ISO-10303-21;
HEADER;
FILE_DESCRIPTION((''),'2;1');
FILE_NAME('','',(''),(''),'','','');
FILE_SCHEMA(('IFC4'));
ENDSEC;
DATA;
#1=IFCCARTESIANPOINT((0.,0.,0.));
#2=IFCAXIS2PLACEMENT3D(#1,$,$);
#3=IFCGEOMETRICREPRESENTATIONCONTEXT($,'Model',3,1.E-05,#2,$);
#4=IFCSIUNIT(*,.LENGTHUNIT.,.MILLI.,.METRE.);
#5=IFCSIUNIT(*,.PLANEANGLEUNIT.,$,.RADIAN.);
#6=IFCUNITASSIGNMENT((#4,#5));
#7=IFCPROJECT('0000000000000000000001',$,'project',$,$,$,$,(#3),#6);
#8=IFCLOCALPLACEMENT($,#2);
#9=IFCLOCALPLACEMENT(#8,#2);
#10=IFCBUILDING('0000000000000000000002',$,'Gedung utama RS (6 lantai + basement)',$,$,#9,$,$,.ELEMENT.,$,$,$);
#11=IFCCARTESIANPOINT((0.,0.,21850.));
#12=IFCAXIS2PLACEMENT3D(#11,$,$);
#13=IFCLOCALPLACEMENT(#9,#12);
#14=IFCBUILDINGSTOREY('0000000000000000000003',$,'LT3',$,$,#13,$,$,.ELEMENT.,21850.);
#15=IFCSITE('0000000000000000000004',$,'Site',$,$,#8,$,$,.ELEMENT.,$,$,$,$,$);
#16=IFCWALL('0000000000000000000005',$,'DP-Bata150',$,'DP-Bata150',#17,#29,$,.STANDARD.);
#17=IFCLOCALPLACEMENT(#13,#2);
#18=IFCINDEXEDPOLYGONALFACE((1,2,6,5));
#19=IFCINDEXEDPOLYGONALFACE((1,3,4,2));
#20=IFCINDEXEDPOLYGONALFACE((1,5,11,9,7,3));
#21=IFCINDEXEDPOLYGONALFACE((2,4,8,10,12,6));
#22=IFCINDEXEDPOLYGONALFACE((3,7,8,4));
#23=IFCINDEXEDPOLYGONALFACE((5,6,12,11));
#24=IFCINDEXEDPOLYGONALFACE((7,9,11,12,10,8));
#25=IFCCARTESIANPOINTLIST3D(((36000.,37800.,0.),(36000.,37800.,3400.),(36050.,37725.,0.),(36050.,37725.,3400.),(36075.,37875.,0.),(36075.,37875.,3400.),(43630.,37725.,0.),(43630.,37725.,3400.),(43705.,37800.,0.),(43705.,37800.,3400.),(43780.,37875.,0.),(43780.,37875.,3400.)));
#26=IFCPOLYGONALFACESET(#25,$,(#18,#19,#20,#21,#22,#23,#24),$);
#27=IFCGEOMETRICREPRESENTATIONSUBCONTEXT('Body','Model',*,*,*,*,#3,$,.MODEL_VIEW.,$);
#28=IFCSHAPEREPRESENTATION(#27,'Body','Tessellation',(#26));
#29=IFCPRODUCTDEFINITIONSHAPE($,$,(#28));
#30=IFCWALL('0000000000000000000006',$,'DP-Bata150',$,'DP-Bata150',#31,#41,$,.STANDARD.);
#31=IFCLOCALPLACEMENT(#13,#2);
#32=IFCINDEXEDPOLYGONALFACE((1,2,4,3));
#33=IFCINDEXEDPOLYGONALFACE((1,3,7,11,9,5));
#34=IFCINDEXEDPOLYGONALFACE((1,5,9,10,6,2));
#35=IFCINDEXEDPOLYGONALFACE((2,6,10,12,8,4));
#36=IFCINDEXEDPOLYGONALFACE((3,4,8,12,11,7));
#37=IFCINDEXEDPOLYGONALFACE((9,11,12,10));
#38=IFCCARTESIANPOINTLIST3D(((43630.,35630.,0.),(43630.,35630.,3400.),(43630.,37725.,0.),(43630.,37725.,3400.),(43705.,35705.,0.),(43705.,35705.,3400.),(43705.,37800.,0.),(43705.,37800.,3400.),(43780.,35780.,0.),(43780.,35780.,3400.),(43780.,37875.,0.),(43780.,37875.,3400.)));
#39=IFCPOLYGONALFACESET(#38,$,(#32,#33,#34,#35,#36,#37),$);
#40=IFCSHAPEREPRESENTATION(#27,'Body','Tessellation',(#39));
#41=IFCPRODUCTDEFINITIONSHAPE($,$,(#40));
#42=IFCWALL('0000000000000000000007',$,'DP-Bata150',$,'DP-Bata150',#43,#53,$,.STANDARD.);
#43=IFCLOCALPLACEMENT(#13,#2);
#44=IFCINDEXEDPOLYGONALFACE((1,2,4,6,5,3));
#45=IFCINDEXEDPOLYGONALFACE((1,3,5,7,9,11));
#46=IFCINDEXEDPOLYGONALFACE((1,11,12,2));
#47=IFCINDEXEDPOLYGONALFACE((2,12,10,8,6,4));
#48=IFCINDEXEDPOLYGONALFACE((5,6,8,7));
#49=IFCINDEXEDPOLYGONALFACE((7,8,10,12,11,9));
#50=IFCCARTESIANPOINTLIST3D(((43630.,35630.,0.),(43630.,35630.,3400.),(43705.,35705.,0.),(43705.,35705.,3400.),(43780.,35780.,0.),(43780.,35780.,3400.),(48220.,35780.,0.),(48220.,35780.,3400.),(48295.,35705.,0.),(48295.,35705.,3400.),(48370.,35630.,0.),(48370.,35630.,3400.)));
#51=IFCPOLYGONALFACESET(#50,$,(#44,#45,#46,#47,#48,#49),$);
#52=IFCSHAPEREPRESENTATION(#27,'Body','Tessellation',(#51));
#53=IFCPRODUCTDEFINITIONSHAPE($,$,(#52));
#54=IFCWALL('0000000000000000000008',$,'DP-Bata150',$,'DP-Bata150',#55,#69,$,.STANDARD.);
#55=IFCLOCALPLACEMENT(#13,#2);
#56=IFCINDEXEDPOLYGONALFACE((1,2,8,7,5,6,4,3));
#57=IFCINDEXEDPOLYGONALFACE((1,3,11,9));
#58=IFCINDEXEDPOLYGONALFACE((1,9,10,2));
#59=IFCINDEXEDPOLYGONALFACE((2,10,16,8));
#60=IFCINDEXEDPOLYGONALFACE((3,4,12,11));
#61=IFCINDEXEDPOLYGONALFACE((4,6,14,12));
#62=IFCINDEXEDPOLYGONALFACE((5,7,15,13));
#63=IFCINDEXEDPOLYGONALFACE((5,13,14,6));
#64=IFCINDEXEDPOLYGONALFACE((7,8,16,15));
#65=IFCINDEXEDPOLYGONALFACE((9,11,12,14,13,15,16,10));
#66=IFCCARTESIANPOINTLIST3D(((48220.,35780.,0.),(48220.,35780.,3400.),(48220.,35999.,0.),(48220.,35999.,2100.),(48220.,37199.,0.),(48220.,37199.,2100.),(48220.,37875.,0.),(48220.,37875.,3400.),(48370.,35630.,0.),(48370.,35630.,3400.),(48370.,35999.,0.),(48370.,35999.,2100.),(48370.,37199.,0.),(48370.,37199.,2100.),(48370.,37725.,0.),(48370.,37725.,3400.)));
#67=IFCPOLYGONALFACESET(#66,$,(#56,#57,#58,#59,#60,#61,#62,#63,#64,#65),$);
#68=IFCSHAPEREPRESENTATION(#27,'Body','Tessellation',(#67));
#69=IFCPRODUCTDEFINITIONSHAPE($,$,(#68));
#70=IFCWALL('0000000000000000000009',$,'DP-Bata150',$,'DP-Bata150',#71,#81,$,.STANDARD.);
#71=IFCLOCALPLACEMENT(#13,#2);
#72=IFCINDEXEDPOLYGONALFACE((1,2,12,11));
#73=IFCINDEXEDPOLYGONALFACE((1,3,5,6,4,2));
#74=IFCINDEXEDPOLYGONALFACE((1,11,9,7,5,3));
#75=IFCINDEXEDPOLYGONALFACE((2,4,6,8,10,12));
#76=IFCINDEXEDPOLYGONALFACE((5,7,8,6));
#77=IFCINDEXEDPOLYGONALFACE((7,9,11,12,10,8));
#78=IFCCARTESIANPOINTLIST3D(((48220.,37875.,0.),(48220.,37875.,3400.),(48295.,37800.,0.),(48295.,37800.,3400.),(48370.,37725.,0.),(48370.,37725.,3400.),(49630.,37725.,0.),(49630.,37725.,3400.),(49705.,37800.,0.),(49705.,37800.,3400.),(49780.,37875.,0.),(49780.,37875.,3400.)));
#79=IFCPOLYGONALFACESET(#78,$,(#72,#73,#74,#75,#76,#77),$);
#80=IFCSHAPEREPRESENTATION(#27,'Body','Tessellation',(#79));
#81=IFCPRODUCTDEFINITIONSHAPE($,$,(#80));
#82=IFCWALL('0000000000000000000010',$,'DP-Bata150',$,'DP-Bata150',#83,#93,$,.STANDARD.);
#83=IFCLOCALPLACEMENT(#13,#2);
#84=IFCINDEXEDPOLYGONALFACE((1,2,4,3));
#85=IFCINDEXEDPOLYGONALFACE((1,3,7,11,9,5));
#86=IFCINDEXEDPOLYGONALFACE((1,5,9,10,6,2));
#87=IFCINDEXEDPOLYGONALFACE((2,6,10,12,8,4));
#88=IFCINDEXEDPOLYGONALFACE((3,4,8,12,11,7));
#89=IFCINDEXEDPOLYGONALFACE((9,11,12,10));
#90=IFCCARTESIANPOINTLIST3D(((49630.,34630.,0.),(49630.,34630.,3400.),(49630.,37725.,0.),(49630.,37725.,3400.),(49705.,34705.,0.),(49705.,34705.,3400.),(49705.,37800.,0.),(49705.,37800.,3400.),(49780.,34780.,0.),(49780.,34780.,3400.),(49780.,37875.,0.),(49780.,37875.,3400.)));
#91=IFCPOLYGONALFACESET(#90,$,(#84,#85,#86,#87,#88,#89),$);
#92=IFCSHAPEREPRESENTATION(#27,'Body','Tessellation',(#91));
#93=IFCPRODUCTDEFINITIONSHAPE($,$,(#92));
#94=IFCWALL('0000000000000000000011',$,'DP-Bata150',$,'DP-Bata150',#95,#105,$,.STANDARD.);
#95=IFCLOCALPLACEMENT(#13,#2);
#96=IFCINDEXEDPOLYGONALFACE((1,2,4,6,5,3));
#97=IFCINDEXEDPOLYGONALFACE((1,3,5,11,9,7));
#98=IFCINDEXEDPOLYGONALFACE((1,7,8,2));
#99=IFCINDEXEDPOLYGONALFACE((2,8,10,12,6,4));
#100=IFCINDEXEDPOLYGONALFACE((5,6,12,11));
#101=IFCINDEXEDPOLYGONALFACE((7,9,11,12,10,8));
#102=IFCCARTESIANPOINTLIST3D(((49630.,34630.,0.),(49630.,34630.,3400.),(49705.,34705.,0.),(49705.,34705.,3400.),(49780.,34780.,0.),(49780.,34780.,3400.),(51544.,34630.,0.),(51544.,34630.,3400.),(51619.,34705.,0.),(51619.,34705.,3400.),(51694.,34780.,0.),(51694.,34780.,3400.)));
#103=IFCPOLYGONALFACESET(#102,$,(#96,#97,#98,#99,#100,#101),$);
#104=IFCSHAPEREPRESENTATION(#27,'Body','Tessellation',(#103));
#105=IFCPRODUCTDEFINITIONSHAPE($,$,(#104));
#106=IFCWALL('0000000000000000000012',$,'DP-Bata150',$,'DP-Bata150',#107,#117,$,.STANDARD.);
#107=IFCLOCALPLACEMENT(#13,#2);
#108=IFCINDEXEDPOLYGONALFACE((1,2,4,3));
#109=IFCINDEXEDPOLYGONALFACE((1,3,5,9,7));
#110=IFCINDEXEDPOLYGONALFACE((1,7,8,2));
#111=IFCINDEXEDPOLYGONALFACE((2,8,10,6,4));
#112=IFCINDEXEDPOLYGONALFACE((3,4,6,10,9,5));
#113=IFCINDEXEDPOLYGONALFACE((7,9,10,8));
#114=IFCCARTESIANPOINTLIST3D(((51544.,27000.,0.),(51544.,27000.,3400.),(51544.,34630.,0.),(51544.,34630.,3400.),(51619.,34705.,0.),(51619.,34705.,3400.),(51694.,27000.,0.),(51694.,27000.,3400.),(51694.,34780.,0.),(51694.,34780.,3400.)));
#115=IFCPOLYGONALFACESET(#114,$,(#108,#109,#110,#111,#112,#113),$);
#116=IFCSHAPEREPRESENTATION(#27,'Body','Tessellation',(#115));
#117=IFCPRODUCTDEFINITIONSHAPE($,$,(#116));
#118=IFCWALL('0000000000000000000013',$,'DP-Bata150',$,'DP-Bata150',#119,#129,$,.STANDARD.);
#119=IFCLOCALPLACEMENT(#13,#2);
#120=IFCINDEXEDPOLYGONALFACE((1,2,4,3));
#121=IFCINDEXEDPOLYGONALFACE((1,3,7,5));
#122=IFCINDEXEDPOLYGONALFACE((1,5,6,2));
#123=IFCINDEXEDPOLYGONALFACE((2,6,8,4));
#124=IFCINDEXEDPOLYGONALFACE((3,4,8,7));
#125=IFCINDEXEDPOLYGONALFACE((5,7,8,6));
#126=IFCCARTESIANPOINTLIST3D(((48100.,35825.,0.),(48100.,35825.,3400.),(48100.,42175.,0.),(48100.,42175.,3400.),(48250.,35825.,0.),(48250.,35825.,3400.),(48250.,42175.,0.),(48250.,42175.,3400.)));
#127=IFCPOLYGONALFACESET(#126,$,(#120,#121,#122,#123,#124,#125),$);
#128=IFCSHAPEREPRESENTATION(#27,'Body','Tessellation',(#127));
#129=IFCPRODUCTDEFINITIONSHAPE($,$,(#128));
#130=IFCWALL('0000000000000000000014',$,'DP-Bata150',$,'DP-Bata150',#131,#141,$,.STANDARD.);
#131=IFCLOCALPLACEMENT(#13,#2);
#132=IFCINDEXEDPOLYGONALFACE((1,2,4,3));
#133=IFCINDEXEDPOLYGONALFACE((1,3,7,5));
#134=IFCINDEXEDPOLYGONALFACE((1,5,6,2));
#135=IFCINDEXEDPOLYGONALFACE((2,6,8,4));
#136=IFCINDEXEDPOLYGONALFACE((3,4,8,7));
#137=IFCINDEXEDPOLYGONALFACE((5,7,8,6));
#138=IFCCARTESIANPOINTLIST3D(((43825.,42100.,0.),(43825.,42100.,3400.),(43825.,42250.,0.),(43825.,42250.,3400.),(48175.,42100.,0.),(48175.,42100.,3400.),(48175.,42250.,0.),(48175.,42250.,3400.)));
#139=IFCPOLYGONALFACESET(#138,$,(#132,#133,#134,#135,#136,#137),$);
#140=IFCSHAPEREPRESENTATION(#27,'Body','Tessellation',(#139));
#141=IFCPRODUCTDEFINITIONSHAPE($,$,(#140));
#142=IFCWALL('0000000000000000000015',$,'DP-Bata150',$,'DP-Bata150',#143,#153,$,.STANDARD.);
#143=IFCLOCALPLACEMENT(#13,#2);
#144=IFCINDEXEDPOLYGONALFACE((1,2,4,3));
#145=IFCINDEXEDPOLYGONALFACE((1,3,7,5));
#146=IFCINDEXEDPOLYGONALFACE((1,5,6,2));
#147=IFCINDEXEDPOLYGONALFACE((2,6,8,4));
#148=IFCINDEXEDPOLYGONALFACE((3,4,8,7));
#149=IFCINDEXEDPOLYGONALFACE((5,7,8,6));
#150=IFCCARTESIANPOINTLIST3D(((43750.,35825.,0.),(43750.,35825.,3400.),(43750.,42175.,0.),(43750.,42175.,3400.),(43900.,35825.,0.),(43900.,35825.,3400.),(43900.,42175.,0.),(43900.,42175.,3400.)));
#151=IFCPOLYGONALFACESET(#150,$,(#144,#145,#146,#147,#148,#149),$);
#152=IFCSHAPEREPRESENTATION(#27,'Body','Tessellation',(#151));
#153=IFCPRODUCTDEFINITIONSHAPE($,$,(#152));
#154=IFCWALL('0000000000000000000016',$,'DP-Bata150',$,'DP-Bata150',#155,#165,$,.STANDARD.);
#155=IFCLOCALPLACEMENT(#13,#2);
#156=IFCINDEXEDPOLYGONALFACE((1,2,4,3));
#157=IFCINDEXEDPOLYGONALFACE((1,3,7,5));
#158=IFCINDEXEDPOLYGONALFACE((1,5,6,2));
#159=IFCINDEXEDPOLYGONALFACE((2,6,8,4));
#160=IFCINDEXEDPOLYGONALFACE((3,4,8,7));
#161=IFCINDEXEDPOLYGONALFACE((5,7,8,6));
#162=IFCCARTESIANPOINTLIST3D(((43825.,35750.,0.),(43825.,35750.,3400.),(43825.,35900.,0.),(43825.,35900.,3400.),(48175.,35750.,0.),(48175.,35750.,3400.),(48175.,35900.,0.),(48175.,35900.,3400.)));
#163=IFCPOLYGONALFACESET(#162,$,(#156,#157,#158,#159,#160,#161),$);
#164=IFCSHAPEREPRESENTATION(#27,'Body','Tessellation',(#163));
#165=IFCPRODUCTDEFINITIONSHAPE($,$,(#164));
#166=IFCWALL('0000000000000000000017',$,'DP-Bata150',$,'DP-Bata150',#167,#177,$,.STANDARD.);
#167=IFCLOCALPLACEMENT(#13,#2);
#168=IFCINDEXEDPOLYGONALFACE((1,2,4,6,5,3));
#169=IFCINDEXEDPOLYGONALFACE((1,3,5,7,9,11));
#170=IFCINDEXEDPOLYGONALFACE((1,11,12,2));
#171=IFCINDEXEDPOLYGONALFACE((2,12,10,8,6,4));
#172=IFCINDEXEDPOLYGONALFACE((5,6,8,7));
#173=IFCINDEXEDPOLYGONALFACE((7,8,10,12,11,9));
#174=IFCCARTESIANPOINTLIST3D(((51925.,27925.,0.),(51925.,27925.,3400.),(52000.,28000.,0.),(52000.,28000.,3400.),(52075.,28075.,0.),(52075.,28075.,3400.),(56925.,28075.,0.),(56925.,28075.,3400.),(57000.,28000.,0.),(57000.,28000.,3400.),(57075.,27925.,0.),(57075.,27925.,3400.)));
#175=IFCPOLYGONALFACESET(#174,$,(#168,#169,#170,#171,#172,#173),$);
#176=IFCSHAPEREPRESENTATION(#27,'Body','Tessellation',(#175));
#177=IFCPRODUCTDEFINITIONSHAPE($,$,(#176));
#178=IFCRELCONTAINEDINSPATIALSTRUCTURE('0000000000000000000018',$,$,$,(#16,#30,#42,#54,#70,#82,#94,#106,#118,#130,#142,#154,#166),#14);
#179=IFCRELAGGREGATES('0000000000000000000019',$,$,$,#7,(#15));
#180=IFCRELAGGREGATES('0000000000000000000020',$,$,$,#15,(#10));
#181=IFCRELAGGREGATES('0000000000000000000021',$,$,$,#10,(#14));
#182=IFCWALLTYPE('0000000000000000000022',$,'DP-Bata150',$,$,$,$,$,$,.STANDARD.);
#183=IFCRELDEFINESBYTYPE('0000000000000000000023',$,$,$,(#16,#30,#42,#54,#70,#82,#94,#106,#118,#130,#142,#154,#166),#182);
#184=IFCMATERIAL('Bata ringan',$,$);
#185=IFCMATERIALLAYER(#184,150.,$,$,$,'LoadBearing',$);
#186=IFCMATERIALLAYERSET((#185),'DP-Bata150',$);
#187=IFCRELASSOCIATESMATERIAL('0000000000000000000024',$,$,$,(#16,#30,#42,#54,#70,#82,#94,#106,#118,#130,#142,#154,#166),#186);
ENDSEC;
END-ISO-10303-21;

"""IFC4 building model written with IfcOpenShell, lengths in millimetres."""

from ifc_helpers import new_model, si_unit, frame, frame_2d, origin, place, context, subcontext, project, spatial, polyline, rectangle, outline, extrude, material, layer, layer_set, layer_usage, type_object, element, save


model = new_model("IFC4")

# Units and contexts
model_context = context("Model", 3, precision=1e-05, world=origin())
body_context = subcontext(model_context, "Body", "Model", "MODEL_VIEW")
ifc_project = project(units=[si_unit("LENGTHUNIT", "METRE", prefix="MILLI"), si_unit("PLANEANGLEUNIT", "RADIAN")], contexts=[model_context])

# Site, building, storey
site_placement = place(None, origin())
site = spatial("IfcSite", under=ifc_project, at=site_placement, Name="Site", CompositionType="ELEMENT")
building_placement = place(site_placement, origin())
building = spatial("IfcBuilding", under=site, at=building_placement, Name="Gedung utama RS (6 lantai + basement)", CompositionType="ELEMENT")
storey_placement = place(building_placement, frame((0.0, 0.0, 21850.0)))
storey = spatial("IfcBuildingStorey", under=building, at=storey_placement, Name="LT3", CompositionType="ELEMENT", Elevation=21850.0)

# Walls
ifc_material_1 = material(Name="Bata ringan")
ifc_layer_1 = layer(ifc_material_1, 150.0, Category="LoadBearing")
ifc_layer_set_1 = layer_set([ifc_layer_1], Name="DP-Bata150")
ifc_layer_usage_1 = layer_usage(ifc_layer_set_1, "AXIS2", "NEGATIVE", 75.0)
wall_type_1 = type_object("IfcWallType", Name="DP-Bata150", PredefinedType="STANDARD")
wall_1_placement = place(storey_placement, frame((36000.0, 37800.0, 0.0), z_axis=(0.0, 0.0, 1.0), x_axis=(1.0, 0.0, 0.0)))
element("IfcWall", 1, at=wall_1_placement, inside=storey, type_object=wall_type_1, material=ifc_layer_usage_1, Name="DP-Bata150", ObjectType="DP-Bata150", PredefinedType="STANDARD", context=body_context, shape_type="SweptSolid", body=[
    extrude(outline(polyline([(50.0, -75.0), (0.0, 0.0), (75.0, 75.0), (7780.0, 75.0), (7705.0, 0.0), (7630.0, -75.0), (50.0, -75.0)])), origin(), (0.0, 0.0, 1.0), 3400.0),
])
wall_2_placement = place(storey_placement, frame((43705.0, 37800.0, 0.0), z_axis=(0.0, 0.0, 1.0), x_axis=(0.0, -1.0, 0.0)))
element("IfcWall", 2, at=wall_2_placement, inside=storey, type_object=wall_type_1, material=ifc_layer_usage_1, Name="DP-Bata150", ObjectType="DP-Bata150", PredefinedType="STANDARD", context=body_context, shape_type="SweptSolid", body=[
    extrude(outline(polyline([(75.0, -75.0), (0.0, 0.0), (-75.0, 75.0), (2020.0, 75.0), (2095.0, 0.0), (2170.0, -75.0), (75.0, -75.0)])), origin(), (0.0, 0.0, 1.0), 3400.0),
])
wall_3_placement = place(storey_placement, frame((43705.0, 35705.0, 0.0), z_axis=(0.0, 0.0, 1.0), x_axis=(1.0, 0.0, 0.0)))
element("IfcWall", 3, at=wall_3_placement, inside=storey, type_object=wall_type_1, material=ifc_layer_usage_1, Name="DP-Bata150", ObjectType="DP-Bata150", PredefinedType="STANDARD", context=body_context, shape_type="SweptSolid", body=[
    extrude(outline(polyline([(-75.0, -75.0), (0.0, 0.0), (75.0, 75.0), (4515.0, 75.0), (4590.0, 0.0), (4665.0, -75.0), (-75.0, -75.0)])), origin(), (0.0, 0.0, 1.0), 3400.0),
])

# Wall, opening
wall_4_placement = place(storey_placement, frame((48295.0, 35705.0, 0.0), z_axis=(0.0, 0.0, 1.0), x_axis=(0.0, 1.0, 0.0)))
wall_4 = element("IfcWall", 4, at=wall_4_placement, inside=storey, type_object=wall_type_1, material=ifc_layer_usage_1, Name="DP-Bata150", ObjectType="DP-Bata150", PredefinedType="STANDARD", context=body_context, shape_type="SweptSolid", body=[
    extrude(outline(polyline([(-75.0, -75.0), (0.0, 0.0), (75.0, 75.0), (2170.0, 75.0), (2095.0, 0.0), (2020.0, -75.0), (-75.0, -75.0)])), origin(), (0.0, 0.0, 1.0), 3400.0),
])
opening_1_placement = place(wall_4_placement, frame((294.0, 0.0, 0.0), z_axis=(0.0, 0.0, 1.0), x_axis=(1.0, 0.0, 0.0)))
element("IfcOpeningElement", 5, at=opening_1_placement, cuts=wall_4, PredefinedType="OPENING", context=body_context, shape_type="SweptSolid", body=[
    extrude(rectangle(XDim=1200.0, YDim=170.0, at=frame_2d((600.0, 0.0))), origin(), (0.0, 0.0, 1.0), 2100.0),
])

# Walls
wall_5_placement = place(storey_placement, frame((48295.0, 37800.0, 0.0), z_axis=(0.0, 0.0, 1.0), x_axis=(1.0, 0.0, 0.0)))
element("IfcWall", 6, at=wall_5_placement, inside=storey, type_object=wall_type_1, material=ifc_layer_usage_1, Name="DP-Bata150", ObjectType="DP-Bata150", PredefinedType="STANDARD", context=body_context, shape_type="SweptSolid", body=[
    extrude(outline(polyline([(75.0, -75.0), (0.0, 0.0), (-75.0, 75.0), (1485.0, 75.0), (1410.0, 0.0), (1335.0, -75.0), (75.0, -75.0)])), origin(), (0.0, 0.0, 1.0), 3400.0),
])
wall_6_placement = place(storey_placement, frame((49705.0, 37800.0, 0.0), z_axis=(0.0, 0.0, 1.0), x_axis=(0.0, -1.0, 0.0)))
element("IfcWall", 7, at=wall_6_placement, inside=storey, type_object=wall_type_1, material=ifc_layer_usage_1, Name="DP-Bata150", ObjectType="DP-Bata150", PredefinedType="STANDARD", context=body_context, shape_type="SweptSolid", body=[
    extrude(outline(polyline([(75.0, -75.0), (0.0, 0.0), (-75.0, 75.0), (3020.0, 75.0), (3095.0, 0.0), (3170.0, -75.0), (75.0, -75.0)])), origin(), (0.0, 0.0, 1.0), 3400.0),
])
wall_7_placement = place(storey_placement, frame((49705.0, 34705.0, 0.0), z_axis=(0.0, 0.0, 1.0), x_axis=(1.0, 0.0, 0.0)))
element("IfcWall", 8, at=wall_7_placement, inside=storey, type_object=wall_type_1, material=ifc_layer_usage_1, Name="DP-Bata150", ObjectType="DP-Bata150", PredefinedType="STANDARD", context=body_context, shape_type="SweptSolid", body=[
    extrude(outline(polyline([(-75.0, -75.0), (0.0, 0.0), (75.0, 75.0), (1989.0, 75.0), (1914.0, 0.0), (1839.0, -75.0), (-75.0, -75.0)])), origin(), (0.0, 0.0, 1.0), 3400.0),
])
wall_8_placement = place(storey_placement, frame((51619.0, 34705.0, 0.0), z_axis=(0.0, 0.0, 1.0), x_axis=(0.0, -1.0, 0.0)))
element("IfcWall", 9, at=wall_8_placement, inside=storey, type_object=wall_type_1, material=ifc_layer_usage_1, Name="DP-Bata150", ObjectType="DP-Bata150", PredefinedType="STANDARD", context=body_context, shape_type="SweptSolid", body=[
    extrude(outline(polyline([(75.0, -75.0), (0.0, 0.0), (-75.0, 75.0), (7705.0, 75.0), (7705.0, -75.0), (75.0, -75.0)])), origin(), (0.0, 0.0, 1.0), 3400.0),
])
wall_9_placement = place(storey_placement, frame((48175.0, 35825.0, 0.0), z_axis=(0.0, 0.0, 1.0), x_axis=(0.0, 1.0, 0.0)))
element("IfcWall", 10, at=wall_9_placement, inside=storey, type_object=wall_type_1, material=ifc_layer_usage_1, Name="DP-Bata150", ObjectType="DP-Bata150", PredefinedType="STANDARD", context=body_context, shape_type="SweptSolid", body=[
    extrude(outline(polyline([(0.0, -75.0), (0.0, 75.0), (6350.0, 75.0), (6350.0, -75.0), (0.0, -75.0)])), origin(), (0.0, 0.0, 1.0), 3400.0),
])
wall_10_placement = place(storey_placement, frame((48175.0, 42175.0, 0.0), z_axis=(0.0, 0.0, 1.0), x_axis=(-1.0, 0.0, 0.0)))
element("IfcWall", 11, at=wall_10_placement, inside=storey, type_object=wall_type_1, material=ifc_layer_usage_1, Name="DP-Bata150", ObjectType="DP-Bata150", PredefinedType="STANDARD", context=body_context, shape_type="SweptSolid", body=[
    extrude(outline(polyline([(0.0, -75.0), (0.0, 75.0), (4350.0, 75.0), (4350.0, -75.0), (0.0, -75.0)])), origin(), (0.0, 0.0, 1.0), 3400.0),
])
wall_11_placement = place(storey_placement, frame((43825.0, 42175.0, 0.0), z_axis=(0.0, 0.0, 1.0), x_axis=(0.0, -1.0, 0.0)))
element("IfcWall", 12, at=wall_11_placement, inside=storey, type_object=wall_type_1, material=ifc_layer_usage_1, Name="DP-Bata150", ObjectType="DP-Bata150", PredefinedType="STANDARD", context=body_context, shape_type="SweptSolid", body=[
    extrude(outline(polyline([(0.0, -75.0), (0.0, 75.0), (6350.0, 75.0), (6350.0, -75.0), (0.0, -75.0)])), origin(), (0.0, 0.0, 1.0), 3400.0),
])
wall_12_placement = place(storey_placement, frame((43825.0, 35825.0, 0.0), z_axis=(0.0, 0.0, 1.0), x_axis=(1.0, 0.0, 0.0)))
element("IfcWall", 13, at=wall_12_placement, inside=storey, type_object=wall_type_1, material=ifc_layer_usage_1, Name="DP-Bata150", ObjectType="DP-Bata150", PredefinedType="STANDARD", context=body_context, shape_type="SweptSolid", body=[
    extrude(outline(polyline([(0.0, -75.0), (0.0, 75.0), (4350.0, 75.0), (4350.0, -75.0), (0.0, -75.0)])), origin(), (0.0, 0.0, 1.0), 3400.0),
])
wall_13_placement = place(storey_placement, frame((52000.0, 28000.0, 0.0), z_axis=(0.0, 0.0, 1.0), x_axis=(1.0, 0.0, 0.0)))
element("IfcWall", 14, at=wall_13_placement, inside=storey, type_object=wall_type_1, material=ifc_layer_usage_1, Name="DP-Bata150", ObjectType="DP-Bata150", PredefinedType="STANDARD", context=body_context, shape_type="SweptSolid", body=[
    extrude(outline(polyline([(-75.0, -75.0), (0.0, 0.0), (75.0, 75.0), (4925.0, 75.0), (5000.0, 0.0), (5075.0, -75.0), (-75.0, -75.0)])), origin(), (0.0, 0.0, 1.0), 3400.0),
])

save(model, "model.ifc")
